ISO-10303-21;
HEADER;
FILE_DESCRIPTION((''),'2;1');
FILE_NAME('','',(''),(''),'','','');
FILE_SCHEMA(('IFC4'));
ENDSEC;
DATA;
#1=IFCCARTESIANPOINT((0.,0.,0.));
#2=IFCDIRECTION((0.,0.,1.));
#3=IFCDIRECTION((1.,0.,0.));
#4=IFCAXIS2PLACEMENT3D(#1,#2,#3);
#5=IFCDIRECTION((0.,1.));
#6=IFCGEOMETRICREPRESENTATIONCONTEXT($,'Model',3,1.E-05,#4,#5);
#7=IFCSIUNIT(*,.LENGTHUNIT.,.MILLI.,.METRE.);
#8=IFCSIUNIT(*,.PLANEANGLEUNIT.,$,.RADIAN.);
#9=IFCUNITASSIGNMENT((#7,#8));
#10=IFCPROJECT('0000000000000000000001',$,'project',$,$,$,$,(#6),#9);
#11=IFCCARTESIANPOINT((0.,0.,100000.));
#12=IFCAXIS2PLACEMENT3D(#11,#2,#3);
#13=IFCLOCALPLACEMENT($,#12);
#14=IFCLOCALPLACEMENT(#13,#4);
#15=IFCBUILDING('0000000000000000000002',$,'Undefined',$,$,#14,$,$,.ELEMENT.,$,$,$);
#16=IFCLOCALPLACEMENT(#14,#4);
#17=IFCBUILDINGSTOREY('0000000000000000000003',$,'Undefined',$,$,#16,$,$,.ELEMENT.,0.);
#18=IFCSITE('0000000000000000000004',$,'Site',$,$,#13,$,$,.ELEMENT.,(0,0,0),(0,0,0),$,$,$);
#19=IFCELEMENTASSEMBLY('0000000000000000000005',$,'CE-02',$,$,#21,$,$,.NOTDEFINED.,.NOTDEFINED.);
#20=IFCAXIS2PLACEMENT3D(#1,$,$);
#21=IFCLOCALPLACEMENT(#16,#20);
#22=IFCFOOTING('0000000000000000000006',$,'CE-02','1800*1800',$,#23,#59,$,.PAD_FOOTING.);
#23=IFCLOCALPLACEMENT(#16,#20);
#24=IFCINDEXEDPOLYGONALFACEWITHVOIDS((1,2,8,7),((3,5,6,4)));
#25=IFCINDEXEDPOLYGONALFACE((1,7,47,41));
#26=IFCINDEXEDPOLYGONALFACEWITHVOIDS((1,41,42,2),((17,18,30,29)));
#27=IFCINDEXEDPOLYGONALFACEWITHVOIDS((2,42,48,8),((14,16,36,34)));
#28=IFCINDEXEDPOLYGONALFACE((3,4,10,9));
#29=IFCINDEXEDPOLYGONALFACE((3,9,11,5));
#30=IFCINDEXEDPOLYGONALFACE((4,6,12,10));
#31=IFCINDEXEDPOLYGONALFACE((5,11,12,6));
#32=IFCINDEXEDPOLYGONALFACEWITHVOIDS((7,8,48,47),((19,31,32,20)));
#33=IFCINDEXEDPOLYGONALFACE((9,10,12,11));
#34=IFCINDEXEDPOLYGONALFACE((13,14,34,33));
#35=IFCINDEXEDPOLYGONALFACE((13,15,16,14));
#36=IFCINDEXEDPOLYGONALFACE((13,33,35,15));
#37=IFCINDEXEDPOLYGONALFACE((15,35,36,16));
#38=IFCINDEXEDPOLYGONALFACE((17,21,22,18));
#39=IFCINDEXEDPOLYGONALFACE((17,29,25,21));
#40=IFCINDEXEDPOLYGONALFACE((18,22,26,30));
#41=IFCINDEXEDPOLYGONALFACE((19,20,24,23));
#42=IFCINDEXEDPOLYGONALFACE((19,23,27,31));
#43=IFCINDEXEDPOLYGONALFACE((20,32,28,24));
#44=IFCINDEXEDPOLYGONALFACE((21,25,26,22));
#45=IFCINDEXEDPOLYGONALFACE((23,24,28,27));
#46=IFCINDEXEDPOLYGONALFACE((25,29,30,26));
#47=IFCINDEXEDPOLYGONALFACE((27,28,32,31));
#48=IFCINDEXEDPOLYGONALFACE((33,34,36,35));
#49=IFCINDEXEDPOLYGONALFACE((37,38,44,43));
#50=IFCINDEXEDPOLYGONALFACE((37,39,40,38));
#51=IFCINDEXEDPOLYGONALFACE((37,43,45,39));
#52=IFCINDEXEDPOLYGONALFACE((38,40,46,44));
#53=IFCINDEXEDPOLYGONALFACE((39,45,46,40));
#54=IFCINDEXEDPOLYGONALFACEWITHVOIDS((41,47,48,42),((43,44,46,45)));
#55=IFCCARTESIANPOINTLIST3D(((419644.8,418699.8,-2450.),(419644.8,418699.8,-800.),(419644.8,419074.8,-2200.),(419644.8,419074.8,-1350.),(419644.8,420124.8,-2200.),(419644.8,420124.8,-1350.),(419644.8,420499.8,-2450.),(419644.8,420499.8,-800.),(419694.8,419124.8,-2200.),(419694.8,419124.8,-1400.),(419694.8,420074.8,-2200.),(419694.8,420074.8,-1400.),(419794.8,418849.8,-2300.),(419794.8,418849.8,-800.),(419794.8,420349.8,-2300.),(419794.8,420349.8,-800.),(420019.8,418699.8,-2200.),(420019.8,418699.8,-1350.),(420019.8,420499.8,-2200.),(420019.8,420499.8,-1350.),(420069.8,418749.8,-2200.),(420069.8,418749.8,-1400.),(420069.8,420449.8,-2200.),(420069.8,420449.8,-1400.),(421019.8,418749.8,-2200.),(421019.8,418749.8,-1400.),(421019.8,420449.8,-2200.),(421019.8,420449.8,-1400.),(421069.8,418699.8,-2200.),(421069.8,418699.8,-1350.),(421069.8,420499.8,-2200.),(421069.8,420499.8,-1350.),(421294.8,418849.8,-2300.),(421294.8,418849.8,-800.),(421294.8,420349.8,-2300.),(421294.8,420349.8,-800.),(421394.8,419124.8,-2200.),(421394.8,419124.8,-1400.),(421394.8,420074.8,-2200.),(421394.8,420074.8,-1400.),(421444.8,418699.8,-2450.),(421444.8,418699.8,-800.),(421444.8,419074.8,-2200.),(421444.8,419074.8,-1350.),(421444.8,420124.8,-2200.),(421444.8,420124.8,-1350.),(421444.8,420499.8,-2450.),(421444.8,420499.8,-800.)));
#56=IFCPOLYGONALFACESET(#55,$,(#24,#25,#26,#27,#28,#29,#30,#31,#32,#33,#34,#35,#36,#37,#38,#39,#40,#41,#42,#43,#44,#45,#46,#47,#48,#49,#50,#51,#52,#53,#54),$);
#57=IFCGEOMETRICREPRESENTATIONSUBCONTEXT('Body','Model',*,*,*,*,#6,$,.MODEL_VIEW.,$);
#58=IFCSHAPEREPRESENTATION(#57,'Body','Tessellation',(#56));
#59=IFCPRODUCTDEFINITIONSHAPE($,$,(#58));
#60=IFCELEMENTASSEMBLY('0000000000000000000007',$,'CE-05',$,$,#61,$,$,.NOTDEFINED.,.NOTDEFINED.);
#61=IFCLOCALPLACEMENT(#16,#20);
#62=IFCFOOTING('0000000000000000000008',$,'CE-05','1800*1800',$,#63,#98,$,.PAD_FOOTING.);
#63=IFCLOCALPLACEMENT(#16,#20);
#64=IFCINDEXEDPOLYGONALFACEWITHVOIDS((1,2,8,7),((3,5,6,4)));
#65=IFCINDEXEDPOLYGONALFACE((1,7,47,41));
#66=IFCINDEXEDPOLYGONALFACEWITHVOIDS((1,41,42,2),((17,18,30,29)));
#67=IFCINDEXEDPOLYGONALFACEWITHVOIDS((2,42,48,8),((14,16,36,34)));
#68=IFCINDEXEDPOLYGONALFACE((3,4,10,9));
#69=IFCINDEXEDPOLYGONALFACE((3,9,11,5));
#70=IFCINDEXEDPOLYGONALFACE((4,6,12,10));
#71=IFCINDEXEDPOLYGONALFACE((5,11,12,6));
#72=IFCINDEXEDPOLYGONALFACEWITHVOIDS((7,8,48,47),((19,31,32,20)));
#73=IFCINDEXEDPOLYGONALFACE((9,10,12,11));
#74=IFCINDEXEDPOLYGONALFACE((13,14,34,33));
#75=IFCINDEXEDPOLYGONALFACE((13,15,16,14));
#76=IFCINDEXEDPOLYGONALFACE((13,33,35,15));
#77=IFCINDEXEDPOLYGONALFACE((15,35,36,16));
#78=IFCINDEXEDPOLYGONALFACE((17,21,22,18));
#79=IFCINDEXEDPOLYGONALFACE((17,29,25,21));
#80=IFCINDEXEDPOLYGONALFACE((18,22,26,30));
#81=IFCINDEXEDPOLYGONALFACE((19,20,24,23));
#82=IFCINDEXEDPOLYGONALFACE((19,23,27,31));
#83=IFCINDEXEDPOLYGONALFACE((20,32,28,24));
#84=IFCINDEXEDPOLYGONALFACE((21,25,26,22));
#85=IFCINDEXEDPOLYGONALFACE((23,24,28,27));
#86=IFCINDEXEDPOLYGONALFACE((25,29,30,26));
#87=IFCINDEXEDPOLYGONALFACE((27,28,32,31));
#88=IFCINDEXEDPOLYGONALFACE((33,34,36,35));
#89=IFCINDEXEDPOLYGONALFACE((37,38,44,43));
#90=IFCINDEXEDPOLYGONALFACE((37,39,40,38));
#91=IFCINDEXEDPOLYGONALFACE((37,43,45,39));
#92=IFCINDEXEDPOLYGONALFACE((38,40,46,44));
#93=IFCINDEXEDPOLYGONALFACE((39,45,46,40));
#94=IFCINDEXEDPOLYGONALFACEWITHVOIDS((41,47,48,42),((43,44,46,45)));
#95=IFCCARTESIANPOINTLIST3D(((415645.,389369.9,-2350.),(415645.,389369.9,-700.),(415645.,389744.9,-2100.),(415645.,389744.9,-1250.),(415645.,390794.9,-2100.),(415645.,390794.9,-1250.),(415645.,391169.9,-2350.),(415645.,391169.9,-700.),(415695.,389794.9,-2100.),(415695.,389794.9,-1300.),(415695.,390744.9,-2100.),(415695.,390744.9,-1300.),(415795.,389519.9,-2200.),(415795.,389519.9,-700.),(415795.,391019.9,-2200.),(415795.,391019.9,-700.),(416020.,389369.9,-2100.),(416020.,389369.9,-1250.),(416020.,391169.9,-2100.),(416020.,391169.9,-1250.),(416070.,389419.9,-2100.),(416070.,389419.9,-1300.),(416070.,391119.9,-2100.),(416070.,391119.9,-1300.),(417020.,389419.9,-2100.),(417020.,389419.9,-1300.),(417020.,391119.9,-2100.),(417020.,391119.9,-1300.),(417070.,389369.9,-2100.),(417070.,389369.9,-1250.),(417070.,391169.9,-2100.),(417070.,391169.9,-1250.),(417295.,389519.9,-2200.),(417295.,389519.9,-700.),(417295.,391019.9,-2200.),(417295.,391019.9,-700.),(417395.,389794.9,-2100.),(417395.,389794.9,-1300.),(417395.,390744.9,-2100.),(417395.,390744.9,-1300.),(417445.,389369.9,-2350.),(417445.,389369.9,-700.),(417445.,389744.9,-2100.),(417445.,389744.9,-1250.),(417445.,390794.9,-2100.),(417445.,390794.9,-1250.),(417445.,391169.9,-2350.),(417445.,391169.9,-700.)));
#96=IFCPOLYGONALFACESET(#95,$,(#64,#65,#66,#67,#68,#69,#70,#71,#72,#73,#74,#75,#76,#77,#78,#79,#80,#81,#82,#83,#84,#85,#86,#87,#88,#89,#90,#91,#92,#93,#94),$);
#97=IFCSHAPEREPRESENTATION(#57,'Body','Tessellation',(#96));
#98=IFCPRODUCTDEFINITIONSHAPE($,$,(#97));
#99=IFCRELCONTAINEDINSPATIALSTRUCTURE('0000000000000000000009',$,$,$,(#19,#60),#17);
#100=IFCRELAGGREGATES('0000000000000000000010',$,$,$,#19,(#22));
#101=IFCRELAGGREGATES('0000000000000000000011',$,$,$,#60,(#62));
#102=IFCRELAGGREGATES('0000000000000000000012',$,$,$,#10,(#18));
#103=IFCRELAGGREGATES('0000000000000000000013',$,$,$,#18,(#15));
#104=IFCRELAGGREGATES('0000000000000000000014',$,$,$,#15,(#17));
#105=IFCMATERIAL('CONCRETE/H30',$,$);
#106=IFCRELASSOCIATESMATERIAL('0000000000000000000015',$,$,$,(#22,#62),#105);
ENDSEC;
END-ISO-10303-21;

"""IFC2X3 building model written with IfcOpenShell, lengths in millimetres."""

from ifc_helpers import new_model, si_unit, direction, frame, origin_with_axes, origin_2d_with_axis, place, context, subcontext, project, spatial, polyline, rectangle, outline, extrude, boolean, material, element, aggregate, save


model = new_model("IFC2X3")

# Units and contexts
model_context = context("Model", 3, precision=1e-05, world=origin_with_axes(), true_north=direction((0.0, 1.0)))
body_context = subcontext(model_context, "Body", "Model", "MODEL_VIEW")
ifc_project = project(units=[si_unit("LENGTHUNIT", "METRE", prefix="MILLI"), si_unit("PLANEANGLEUNIT", "RADIAN")], contexts=[model_context])

# Site, building, storey
site_placement = place(None, frame((0.0, 0.0, 100000.0), z_axis=(0.0, 0.0, 1.0), x_axis=(1.0, 0.0, 0.0)))
site = spatial("IfcSite", under=ifc_project, at=site_placement, Name="Site", CompositionType="ELEMENT", RefLatitude=(0, 0, 0), RefLongitude=(0, 0, 0))
building_placement = place(site_placement, origin_with_axes())
building = spatial("IfcBuilding", under=site, at=building_placement, Name="Undefined", CompositionType="ELEMENT")
storey_placement = place(building_placement, origin_with_axes())
storey = spatial("IfcBuildingStorey", under=building, at=storey_placement, Name="Undefined", CompositionType="ELEMENT", Elevation=0.0)

# Element assemblies, footings
ifc_material_1 = material(Name="CONCRETE/H30")
assembly_1_placement = place(storey_placement, origin_with_axes())
assembly_1 = element("IfcElementAssembly", 1, at=assembly_1_placement, inside=storey, Name="CE-02", AssemblyPlace="NOTDEFINED", PredefinedType="NOTDEFINED")
footing_1_placement = place(assembly_1_placement, frame((420544.8, 419599.8, -2450.0), z_axis=(0.0, 1.0, 0.0), x_axis=(0.0, 0.0, 1.0)))
solid_1 = boolean("DIFFERENCE", boolean("DIFFERENCE", boolean("DIFFERENCE", extrude(outline(polyline([(0.0, 0.0), (1050.0, 0.0), (1050.0, 850.0), (0.0, 850.0), (0.0, 0.0)])), frame((1100.0, 900.0, -525.0), z_axis=(0.0, -1.0, 0.0), x_axis=(0.0, 0.0, 1.0)), (0.0, 0.0, 1.0), 50.0), extrude(outline(polyline([(0.0, 0.0), (70.7, 0.0), (70.7, 850.0), (0.0, 850.0), (0.0, 0.0)])), frame((1100.0, 708.6, -616.4), z_axis=(0.0, 0.707107, 0.707107), x_axis=(0.0, 0.707107, -0.707107)), (0.0, 0.0, 1.0), 200.0)), extrude(outline(polyline([(0.0, 0.0), (70.7, 0.0), (70.7, 850.0), (0.0, 850.0), (0.0, 0.0)])), frame((1100.0, 758.6, 666.4), z_axis=(0.0, 0.707107, -0.707107), x_axis=(0.0, -0.707107, -0.707107)), (0.0, 0.0, 1.0), 200.0)), extrude(outline(polyline([(0.0, 0.0), (70.7, 0.0), (70.7, 1050.0), (0.0, 1050.0), (0.0, 0.0)])), frame((1050.0, 850.0, -525.0), z_axis=(0.707107, -0.707107, 0.0), x_axis=(0.707107, 0.707107, 0.0)), (0.0, 0.0, 1.0), 200.0))
solid_2 = boolean("DIFFERENCE", boolean("DIFFERENCE", boolean("DIFFERENCE", extrude(outline(polyline([(0.0, 0.0), (1050.0, 0.0), (1050.0, 850.0), (0.0, 850.0), (0.0, 0.0)])), frame((1100.0, -525.0, -900.0), z_axis=(0.0, 0.0, 1.0), x_axis=(0.0, 1.0, 0.0)), (0.0, 0.0, 1.0), 50.0), extrude(outline(polyline([(0.0, 0.0), (70.7, 0.0), (70.7, 850.0), (0.0, 850.0), (0.0, 0.0)])), frame((1100.0, -616.4, -708.6), z_axis=(0.0, 0.707107, -0.707107), x_axis=(0.0, -0.707107, -0.707107)), (0.0, 0.0, 1.0), 200.0)), extrude(outline(polyline([(0.0, 0.0), (70.7, 0.0), (70.7, 850.0), (0.0, 850.0), (0.0, 0.0)])), frame((1100.0, 666.4, -758.6), z_axis=(0.0, -0.707107, -0.707107), x_axis=(0.0, -0.707107, 0.707107)), (0.0, 0.0, 1.0), 200.0)), extrude(outline(polyline([(0.0, 0.0), (70.7, 0.0), (70.7, 1050.0), (0.0, 1050.0), (0.0, 0.0)])), frame((1050.0, -525.0, -850.0), z_axis=(0.707107, 0.0, 0.707107), x_axis=(0.707107, 0.0, -0.707107)), (0.0, 0.0, 1.0), 200.0))
solid_3 = boolean("DIFFERENCE", boolean("DIFFERENCE", boolean("DIFFERENCE", extrude(outline(polyline([(0.0, 0.0), (1050.0, 0.0), (1050.0, 850.0), (0.0, 850.0), (0.0, 0.0)])), frame((1100.0, -525.0, 850.0), z_axis=(0.0, 0.0, 1.0), x_axis=(0.0, 1.0, 0.0)), (0.0, 0.0, 1.0), 50.0), extrude(outline(polyline([(0.0, 0.0), (70.7, 0.0), (70.7, 850.0), (0.0, 850.0), (0.0, 0.0)])), frame((1100.0, -475.0, 850.0), z_axis=(0.0, -0.707107, -0.707107), x_axis=(0.0, -0.707107, 0.707107)), (0.0, 0.0, 1.0), 200.0)), extrude(outline(polyline([(0.0, 0.0), (70.7, 0.0), (70.7, 850.0), (0.0, 850.0), (0.0, 0.0)])), frame((1100.0, 525.0, 900.0), z_axis=(0.0, 0.707107, -0.707107), x_axis=(0.0, -0.707107, -0.707107)), (0.0, 0.0, 1.0), 200.0)), extrude(outline(polyline([(0.0, 0.0), (70.7, 0.0), (70.7, 1050.0), (0.0, 1050.0), (0.0, 0.0)])), frame((1191.4, -525.0, 708.6), z_axis=(-0.707107, 0.0, 0.707107), x_axis=(0.707107, 0.0, 0.707107)), (0.0, 0.0, 1.0), 200.0))
solid_4 = boolean("DIFFERENCE", boolean("DIFFERENCE", boolean("DIFFERENCE", extrude(outline(polyline([(0.0, 0.0), (1050.0, 0.0), (1050.0, 850.0), (0.0, 850.0), (0.0, 0.0)])), frame((1100.0, -850.0, -525.0), z_axis=(0.0, -1.0, 0.0), x_axis=(0.0, 0.0, 1.0)), (0.0, 0.0, 1.0), 50.0), extrude(outline(polyline([(0.0, 0.0), (70.7, 0.0), (70.7, 850.0), (0.0, 850.0), (0.0, 0.0)])), frame((1100.0, -850.0, -475.0), z_axis=(0.0, 0.707107, -0.707107), x_axis=(0.0, -0.707107, -0.707107)), (0.0, 0.0, 1.0), 200.0)), extrude(outline(polyline([(0.0, 0.0), (70.7, 0.0), (70.7, 850.0), (0.0, 850.0), (0.0, 0.0)])), frame((1100.0, -900.0, 525.0), z_axis=(0.0, 0.707107, 0.707107), x_axis=(0.0, 0.707107, -0.707107)), (0.0, 0.0, 1.0), 200.0)), extrude(outline(polyline([(0.0, 0.0), (70.7, 0.0), (70.7, 1050.0), (0.0, 1050.0), (0.0, 0.0)])), frame((1191.4, -708.6, -525.0), z_axis=(-0.707107, -0.707107, 0.0), x_axis=(0.707107, -0.707107, 0.0)), (0.0, 0.0, 1.0), 200.0))
footing_1 = element("IfcFooting", 2, at=footing_1_placement, material=ifc_material_1, Name="CE-02", Description="1800*1800", PredefinedType="PAD_FOOTING", context=body_context, shape_type="CSG", body=[
    boolean("DIFFERENCE", boolean("DIFFERENCE", boolean("DIFFERENCE", boolean("DIFFERENCE", boolean("DIFFERENCE", extrude(rectangle(XDim=1800.0, YDim=1800.0, at=origin_2d_with_axis()), frame((1650.0, 0.0, 0.0), z_axis=(-1.0, 0.0, 0.0), x_axis=(0.0, -1.0, 0.0)), (0.0, 0.0, 1.0), 1650.0), solid_1), solid_2), solid_3), solid_4), extrude(rectangle(XDim=1500.0, YDim=1500.0, at=origin_2d_with_axis()), frame((1650.0, 0.0, 0.0), z_axis=(-1.0, 0.0, 0.0), x_axis=(0.0, -1.0, 0.0)), (0.0, 0.0, 1.0), 1500.0)),
])
aggregate(assembly_1, [footing_1])
assembly_2_placement = place(storey_placement, origin_with_axes())
assembly_2 = element("IfcElementAssembly", 3, at=assembly_2_placement, inside=storey, Name="CE-05", AssemblyPlace="NOTDEFINED", PredefinedType="NOTDEFINED")
footing_2_placement = place(assembly_2_placement, frame((416545.0, 390269.9, -2350.0), z_axis=(0.0, 1.0, 0.0), x_axis=(0.0, 0.0, 1.0)))
solid_5 = boolean("DIFFERENCE", boolean("DIFFERENCE", boolean("DIFFERENCE", extrude(outline(polyline([(0.0, 0.0), (1050.0, 0.0), (1050.0, 850.0), (0.0, 850.0), (0.0, 0.0)])), frame((1100.0, 900.0, -525.0), z_axis=(0.0, -1.0, 0.0), x_axis=(0.0, 0.0, 1.0)), (0.0, 0.0, 1.0), 50.0), extrude(outline(polyline([(0.0, 0.0), (70.7, 0.0), (70.7, 850.0), (0.0, 850.0), (0.0, 0.0)])), frame((1100.0, 708.6, -616.4), z_axis=(0.0, 0.707107, 0.707107), x_axis=(0.0, 0.707107, -0.707107)), (0.0, 0.0, 1.0), 200.0)), extrude(outline(polyline([(0.0, 0.0), (70.7, 0.0), (70.7, 850.0), (0.0, 850.0), (0.0, 0.0)])), frame((1100.0, 758.6, 666.4), z_axis=(0.0, 0.707107, -0.707107), x_axis=(0.0, -0.707107, -0.707107)), (0.0, 0.0, 1.0), 200.0)), extrude(outline(polyline([(0.0, 0.0), (70.7, 0.0), (70.7, 1050.0), (0.0, 1050.0), (0.0, 0.0)])), frame((1050.0, 850.0, -525.0), z_axis=(0.707107, -0.707107, 0.0), x_axis=(0.707107, 0.707107, 0.0)), (0.0, 0.0, 1.0), 200.0))
solid_6 = boolean("DIFFERENCE", boolean("DIFFERENCE", boolean("DIFFERENCE", extrude(outline(polyline([(0.0, 0.0), (1050.0, 0.0), (1050.0, 850.0), (0.0, 850.0), (0.0, 0.0)])), frame((1100.0, -525.0, -900.0), z_axis=(0.0, 0.0, 1.0), x_axis=(0.0, 1.0, 0.0)), (0.0, 0.0, 1.0), 50.0), extrude(outline(polyline([(0.0, 0.0), (70.7, 0.0), (70.7, 850.0), (0.0, 850.0), (0.0, 0.0)])), frame((1100.0, -616.4, -708.6), z_axis=(0.0, 0.707107, -0.707107), x_axis=(0.0, -0.707107, -0.707107)), (0.0, 0.0, 1.0), 200.0)), extrude(outline(polyline([(0.0, 0.0), (70.7, 0.0), (70.7, 850.0), (0.0, 850.0), (0.0, 0.0)])), frame((1100.0, 666.4, -758.6), z_axis=(0.0, -0.707107, -0.707107), x_axis=(0.0, -0.707107, 0.707107)), (0.0, 0.0, 1.0), 200.0)), extrude(outline(polyline([(0.0, 0.0), (70.7, 0.0), (70.7, 1050.0), (0.0, 1050.0), (0.0, 0.0)])), frame((1050.0, -525.0, -850.0), z_axis=(0.707107, 0.0, 0.707107), x_axis=(0.707107, 0.0, -0.707107)), (0.0, 0.0, 1.0), 200.0))
solid_7 = boolean("DIFFERENCE", boolean("DIFFERENCE", boolean("DIFFERENCE", extrude(outline(polyline([(0.0, 0.0), (1050.0, 0.0), (1050.0, 850.0), (0.0, 850.0), (0.0, 0.0)])), frame((1100.0, -525.0, 850.0), z_axis=(0.0, 0.0, 1.0), x_axis=(0.0, 1.0, 0.0)), (0.0, 0.0, 1.0), 50.0), extrude(outline(polyline([(0.0, 0.0), (70.7, 0.0), (70.7, 850.0), (0.0, 850.0), (0.0, 0.0)])), frame((1100.0, -475.0, 850.0), z_axis=(0.0, -0.707107, -0.707107), x_axis=(0.0, -0.707107, 0.707107)), (0.0, 0.0, 1.0), 200.0)), extrude(outline(polyline([(0.0, 0.0), (70.7, 0.0), (70.7, 850.0), (0.0, 850.0), (0.0, 0.0)])), frame((1100.0, 525.0, 900.0), z_axis=(0.0, 0.707107, -0.707107), x_axis=(0.0, -0.707107, -0.707107)), (0.0, 0.0, 1.0), 200.0)), extrude(outline(polyline([(0.0, 0.0), (70.7, 0.0), (70.7, 1050.0), (0.0, 1050.0), (0.0, 0.0)])), frame((1191.4, -525.0, 708.6), z_axis=(-0.707107, 0.0, 0.707107), x_axis=(0.707107, 0.0, 0.707107)), (0.0, 0.0, 1.0), 200.0))
solid_8 = boolean("DIFFERENCE", boolean("DIFFERENCE", boolean("DIFFERENCE", extrude(outline(polyline([(0.0, 0.0), (1050.0, 0.0), (1050.0, 850.0), (0.0, 850.0), (0.0, 0.0)])), frame((1100.0, -850.0, -525.0), z_axis=(0.0, -1.0, 0.0), x_axis=(0.0, 0.0, 1.0)), (0.0, 0.0, 1.0), 50.0), extrude(outline(polyline([(0.0, 0.0), (70.7, 0.0), (70.7, 850.0), (0.0, 850.0), (0.0, 0.0)])), frame((1100.0, -850.0, -475.0), z_axis=(0.0, 0.707107, -0.707107), x_axis=(0.0, -0.707107, -0.707107)), (0.0, 0.0, 1.0), 200.0)), extrude(outline(polyline([(0.0, 0.0), (70.7, 0.0), (70.7, 850.0), (0.0, 850.0), (0.0, 0.0)])), frame((1100.0, -900.0, 525.0), z_axis=(0.0, 0.707107, 0.707107), x_axis=(0.0, 0.707107, -0.707107)), (0.0, 0.0, 1.0), 200.0)), extrude(outline(polyline([(0.0, 0.0), (70.7, 0.0), (70.7, 1050.0), (0.0, 1050.0), (0.0, 0.0)])), frame((1191.4, -708.6, -525.0), z_axis=(-0.707107, -0.707107, 0.0), x_axis=(0.707107, -0.707107, 0.0)), (0.0, 0.0, 1.0), 200.0))
footing_2 = element("IfcFooting", 4, at=footing_2_placement, material=ifc_material_1, Name="CE-05", Description="1800*1800", PredefinedType="PAD_FOOTING", context=body_context, shape_type="CSG", body=[
    boolean("DIFFERENCE", boolean("DIFFERENCE", boolean("DIFFERENCE", boolean("DIFFERENCE", boolean("DIFFERENCE", extrude(rectangle(XDim=1800.0, YDim=1800.0, at=origin_2d_with_axis()), frame((1650.0, 0.0, 0.0), z_axis=(-1.0, 0.0, 0.0), x_axis=(0.0, -1.0, 0.0)), (0.0, 0.0, 1.0), 1650.0), solid_5), solid_6), solid_7), solid_8), extrude(rectangle(XDim=1500.0, YDim=1500.0, at=origin_2d_with_axis()), frame((1650.0, 0.0, 0.0), z_axis=(-1.0, 0.0, 0.0), x_axis=(0.0, -1.0, 0.0)), (0.0, 0.0, 1.0), 1500.0)),
])
aggregate(assembly_2, [footing_2])

save(model, "model.ifc")
